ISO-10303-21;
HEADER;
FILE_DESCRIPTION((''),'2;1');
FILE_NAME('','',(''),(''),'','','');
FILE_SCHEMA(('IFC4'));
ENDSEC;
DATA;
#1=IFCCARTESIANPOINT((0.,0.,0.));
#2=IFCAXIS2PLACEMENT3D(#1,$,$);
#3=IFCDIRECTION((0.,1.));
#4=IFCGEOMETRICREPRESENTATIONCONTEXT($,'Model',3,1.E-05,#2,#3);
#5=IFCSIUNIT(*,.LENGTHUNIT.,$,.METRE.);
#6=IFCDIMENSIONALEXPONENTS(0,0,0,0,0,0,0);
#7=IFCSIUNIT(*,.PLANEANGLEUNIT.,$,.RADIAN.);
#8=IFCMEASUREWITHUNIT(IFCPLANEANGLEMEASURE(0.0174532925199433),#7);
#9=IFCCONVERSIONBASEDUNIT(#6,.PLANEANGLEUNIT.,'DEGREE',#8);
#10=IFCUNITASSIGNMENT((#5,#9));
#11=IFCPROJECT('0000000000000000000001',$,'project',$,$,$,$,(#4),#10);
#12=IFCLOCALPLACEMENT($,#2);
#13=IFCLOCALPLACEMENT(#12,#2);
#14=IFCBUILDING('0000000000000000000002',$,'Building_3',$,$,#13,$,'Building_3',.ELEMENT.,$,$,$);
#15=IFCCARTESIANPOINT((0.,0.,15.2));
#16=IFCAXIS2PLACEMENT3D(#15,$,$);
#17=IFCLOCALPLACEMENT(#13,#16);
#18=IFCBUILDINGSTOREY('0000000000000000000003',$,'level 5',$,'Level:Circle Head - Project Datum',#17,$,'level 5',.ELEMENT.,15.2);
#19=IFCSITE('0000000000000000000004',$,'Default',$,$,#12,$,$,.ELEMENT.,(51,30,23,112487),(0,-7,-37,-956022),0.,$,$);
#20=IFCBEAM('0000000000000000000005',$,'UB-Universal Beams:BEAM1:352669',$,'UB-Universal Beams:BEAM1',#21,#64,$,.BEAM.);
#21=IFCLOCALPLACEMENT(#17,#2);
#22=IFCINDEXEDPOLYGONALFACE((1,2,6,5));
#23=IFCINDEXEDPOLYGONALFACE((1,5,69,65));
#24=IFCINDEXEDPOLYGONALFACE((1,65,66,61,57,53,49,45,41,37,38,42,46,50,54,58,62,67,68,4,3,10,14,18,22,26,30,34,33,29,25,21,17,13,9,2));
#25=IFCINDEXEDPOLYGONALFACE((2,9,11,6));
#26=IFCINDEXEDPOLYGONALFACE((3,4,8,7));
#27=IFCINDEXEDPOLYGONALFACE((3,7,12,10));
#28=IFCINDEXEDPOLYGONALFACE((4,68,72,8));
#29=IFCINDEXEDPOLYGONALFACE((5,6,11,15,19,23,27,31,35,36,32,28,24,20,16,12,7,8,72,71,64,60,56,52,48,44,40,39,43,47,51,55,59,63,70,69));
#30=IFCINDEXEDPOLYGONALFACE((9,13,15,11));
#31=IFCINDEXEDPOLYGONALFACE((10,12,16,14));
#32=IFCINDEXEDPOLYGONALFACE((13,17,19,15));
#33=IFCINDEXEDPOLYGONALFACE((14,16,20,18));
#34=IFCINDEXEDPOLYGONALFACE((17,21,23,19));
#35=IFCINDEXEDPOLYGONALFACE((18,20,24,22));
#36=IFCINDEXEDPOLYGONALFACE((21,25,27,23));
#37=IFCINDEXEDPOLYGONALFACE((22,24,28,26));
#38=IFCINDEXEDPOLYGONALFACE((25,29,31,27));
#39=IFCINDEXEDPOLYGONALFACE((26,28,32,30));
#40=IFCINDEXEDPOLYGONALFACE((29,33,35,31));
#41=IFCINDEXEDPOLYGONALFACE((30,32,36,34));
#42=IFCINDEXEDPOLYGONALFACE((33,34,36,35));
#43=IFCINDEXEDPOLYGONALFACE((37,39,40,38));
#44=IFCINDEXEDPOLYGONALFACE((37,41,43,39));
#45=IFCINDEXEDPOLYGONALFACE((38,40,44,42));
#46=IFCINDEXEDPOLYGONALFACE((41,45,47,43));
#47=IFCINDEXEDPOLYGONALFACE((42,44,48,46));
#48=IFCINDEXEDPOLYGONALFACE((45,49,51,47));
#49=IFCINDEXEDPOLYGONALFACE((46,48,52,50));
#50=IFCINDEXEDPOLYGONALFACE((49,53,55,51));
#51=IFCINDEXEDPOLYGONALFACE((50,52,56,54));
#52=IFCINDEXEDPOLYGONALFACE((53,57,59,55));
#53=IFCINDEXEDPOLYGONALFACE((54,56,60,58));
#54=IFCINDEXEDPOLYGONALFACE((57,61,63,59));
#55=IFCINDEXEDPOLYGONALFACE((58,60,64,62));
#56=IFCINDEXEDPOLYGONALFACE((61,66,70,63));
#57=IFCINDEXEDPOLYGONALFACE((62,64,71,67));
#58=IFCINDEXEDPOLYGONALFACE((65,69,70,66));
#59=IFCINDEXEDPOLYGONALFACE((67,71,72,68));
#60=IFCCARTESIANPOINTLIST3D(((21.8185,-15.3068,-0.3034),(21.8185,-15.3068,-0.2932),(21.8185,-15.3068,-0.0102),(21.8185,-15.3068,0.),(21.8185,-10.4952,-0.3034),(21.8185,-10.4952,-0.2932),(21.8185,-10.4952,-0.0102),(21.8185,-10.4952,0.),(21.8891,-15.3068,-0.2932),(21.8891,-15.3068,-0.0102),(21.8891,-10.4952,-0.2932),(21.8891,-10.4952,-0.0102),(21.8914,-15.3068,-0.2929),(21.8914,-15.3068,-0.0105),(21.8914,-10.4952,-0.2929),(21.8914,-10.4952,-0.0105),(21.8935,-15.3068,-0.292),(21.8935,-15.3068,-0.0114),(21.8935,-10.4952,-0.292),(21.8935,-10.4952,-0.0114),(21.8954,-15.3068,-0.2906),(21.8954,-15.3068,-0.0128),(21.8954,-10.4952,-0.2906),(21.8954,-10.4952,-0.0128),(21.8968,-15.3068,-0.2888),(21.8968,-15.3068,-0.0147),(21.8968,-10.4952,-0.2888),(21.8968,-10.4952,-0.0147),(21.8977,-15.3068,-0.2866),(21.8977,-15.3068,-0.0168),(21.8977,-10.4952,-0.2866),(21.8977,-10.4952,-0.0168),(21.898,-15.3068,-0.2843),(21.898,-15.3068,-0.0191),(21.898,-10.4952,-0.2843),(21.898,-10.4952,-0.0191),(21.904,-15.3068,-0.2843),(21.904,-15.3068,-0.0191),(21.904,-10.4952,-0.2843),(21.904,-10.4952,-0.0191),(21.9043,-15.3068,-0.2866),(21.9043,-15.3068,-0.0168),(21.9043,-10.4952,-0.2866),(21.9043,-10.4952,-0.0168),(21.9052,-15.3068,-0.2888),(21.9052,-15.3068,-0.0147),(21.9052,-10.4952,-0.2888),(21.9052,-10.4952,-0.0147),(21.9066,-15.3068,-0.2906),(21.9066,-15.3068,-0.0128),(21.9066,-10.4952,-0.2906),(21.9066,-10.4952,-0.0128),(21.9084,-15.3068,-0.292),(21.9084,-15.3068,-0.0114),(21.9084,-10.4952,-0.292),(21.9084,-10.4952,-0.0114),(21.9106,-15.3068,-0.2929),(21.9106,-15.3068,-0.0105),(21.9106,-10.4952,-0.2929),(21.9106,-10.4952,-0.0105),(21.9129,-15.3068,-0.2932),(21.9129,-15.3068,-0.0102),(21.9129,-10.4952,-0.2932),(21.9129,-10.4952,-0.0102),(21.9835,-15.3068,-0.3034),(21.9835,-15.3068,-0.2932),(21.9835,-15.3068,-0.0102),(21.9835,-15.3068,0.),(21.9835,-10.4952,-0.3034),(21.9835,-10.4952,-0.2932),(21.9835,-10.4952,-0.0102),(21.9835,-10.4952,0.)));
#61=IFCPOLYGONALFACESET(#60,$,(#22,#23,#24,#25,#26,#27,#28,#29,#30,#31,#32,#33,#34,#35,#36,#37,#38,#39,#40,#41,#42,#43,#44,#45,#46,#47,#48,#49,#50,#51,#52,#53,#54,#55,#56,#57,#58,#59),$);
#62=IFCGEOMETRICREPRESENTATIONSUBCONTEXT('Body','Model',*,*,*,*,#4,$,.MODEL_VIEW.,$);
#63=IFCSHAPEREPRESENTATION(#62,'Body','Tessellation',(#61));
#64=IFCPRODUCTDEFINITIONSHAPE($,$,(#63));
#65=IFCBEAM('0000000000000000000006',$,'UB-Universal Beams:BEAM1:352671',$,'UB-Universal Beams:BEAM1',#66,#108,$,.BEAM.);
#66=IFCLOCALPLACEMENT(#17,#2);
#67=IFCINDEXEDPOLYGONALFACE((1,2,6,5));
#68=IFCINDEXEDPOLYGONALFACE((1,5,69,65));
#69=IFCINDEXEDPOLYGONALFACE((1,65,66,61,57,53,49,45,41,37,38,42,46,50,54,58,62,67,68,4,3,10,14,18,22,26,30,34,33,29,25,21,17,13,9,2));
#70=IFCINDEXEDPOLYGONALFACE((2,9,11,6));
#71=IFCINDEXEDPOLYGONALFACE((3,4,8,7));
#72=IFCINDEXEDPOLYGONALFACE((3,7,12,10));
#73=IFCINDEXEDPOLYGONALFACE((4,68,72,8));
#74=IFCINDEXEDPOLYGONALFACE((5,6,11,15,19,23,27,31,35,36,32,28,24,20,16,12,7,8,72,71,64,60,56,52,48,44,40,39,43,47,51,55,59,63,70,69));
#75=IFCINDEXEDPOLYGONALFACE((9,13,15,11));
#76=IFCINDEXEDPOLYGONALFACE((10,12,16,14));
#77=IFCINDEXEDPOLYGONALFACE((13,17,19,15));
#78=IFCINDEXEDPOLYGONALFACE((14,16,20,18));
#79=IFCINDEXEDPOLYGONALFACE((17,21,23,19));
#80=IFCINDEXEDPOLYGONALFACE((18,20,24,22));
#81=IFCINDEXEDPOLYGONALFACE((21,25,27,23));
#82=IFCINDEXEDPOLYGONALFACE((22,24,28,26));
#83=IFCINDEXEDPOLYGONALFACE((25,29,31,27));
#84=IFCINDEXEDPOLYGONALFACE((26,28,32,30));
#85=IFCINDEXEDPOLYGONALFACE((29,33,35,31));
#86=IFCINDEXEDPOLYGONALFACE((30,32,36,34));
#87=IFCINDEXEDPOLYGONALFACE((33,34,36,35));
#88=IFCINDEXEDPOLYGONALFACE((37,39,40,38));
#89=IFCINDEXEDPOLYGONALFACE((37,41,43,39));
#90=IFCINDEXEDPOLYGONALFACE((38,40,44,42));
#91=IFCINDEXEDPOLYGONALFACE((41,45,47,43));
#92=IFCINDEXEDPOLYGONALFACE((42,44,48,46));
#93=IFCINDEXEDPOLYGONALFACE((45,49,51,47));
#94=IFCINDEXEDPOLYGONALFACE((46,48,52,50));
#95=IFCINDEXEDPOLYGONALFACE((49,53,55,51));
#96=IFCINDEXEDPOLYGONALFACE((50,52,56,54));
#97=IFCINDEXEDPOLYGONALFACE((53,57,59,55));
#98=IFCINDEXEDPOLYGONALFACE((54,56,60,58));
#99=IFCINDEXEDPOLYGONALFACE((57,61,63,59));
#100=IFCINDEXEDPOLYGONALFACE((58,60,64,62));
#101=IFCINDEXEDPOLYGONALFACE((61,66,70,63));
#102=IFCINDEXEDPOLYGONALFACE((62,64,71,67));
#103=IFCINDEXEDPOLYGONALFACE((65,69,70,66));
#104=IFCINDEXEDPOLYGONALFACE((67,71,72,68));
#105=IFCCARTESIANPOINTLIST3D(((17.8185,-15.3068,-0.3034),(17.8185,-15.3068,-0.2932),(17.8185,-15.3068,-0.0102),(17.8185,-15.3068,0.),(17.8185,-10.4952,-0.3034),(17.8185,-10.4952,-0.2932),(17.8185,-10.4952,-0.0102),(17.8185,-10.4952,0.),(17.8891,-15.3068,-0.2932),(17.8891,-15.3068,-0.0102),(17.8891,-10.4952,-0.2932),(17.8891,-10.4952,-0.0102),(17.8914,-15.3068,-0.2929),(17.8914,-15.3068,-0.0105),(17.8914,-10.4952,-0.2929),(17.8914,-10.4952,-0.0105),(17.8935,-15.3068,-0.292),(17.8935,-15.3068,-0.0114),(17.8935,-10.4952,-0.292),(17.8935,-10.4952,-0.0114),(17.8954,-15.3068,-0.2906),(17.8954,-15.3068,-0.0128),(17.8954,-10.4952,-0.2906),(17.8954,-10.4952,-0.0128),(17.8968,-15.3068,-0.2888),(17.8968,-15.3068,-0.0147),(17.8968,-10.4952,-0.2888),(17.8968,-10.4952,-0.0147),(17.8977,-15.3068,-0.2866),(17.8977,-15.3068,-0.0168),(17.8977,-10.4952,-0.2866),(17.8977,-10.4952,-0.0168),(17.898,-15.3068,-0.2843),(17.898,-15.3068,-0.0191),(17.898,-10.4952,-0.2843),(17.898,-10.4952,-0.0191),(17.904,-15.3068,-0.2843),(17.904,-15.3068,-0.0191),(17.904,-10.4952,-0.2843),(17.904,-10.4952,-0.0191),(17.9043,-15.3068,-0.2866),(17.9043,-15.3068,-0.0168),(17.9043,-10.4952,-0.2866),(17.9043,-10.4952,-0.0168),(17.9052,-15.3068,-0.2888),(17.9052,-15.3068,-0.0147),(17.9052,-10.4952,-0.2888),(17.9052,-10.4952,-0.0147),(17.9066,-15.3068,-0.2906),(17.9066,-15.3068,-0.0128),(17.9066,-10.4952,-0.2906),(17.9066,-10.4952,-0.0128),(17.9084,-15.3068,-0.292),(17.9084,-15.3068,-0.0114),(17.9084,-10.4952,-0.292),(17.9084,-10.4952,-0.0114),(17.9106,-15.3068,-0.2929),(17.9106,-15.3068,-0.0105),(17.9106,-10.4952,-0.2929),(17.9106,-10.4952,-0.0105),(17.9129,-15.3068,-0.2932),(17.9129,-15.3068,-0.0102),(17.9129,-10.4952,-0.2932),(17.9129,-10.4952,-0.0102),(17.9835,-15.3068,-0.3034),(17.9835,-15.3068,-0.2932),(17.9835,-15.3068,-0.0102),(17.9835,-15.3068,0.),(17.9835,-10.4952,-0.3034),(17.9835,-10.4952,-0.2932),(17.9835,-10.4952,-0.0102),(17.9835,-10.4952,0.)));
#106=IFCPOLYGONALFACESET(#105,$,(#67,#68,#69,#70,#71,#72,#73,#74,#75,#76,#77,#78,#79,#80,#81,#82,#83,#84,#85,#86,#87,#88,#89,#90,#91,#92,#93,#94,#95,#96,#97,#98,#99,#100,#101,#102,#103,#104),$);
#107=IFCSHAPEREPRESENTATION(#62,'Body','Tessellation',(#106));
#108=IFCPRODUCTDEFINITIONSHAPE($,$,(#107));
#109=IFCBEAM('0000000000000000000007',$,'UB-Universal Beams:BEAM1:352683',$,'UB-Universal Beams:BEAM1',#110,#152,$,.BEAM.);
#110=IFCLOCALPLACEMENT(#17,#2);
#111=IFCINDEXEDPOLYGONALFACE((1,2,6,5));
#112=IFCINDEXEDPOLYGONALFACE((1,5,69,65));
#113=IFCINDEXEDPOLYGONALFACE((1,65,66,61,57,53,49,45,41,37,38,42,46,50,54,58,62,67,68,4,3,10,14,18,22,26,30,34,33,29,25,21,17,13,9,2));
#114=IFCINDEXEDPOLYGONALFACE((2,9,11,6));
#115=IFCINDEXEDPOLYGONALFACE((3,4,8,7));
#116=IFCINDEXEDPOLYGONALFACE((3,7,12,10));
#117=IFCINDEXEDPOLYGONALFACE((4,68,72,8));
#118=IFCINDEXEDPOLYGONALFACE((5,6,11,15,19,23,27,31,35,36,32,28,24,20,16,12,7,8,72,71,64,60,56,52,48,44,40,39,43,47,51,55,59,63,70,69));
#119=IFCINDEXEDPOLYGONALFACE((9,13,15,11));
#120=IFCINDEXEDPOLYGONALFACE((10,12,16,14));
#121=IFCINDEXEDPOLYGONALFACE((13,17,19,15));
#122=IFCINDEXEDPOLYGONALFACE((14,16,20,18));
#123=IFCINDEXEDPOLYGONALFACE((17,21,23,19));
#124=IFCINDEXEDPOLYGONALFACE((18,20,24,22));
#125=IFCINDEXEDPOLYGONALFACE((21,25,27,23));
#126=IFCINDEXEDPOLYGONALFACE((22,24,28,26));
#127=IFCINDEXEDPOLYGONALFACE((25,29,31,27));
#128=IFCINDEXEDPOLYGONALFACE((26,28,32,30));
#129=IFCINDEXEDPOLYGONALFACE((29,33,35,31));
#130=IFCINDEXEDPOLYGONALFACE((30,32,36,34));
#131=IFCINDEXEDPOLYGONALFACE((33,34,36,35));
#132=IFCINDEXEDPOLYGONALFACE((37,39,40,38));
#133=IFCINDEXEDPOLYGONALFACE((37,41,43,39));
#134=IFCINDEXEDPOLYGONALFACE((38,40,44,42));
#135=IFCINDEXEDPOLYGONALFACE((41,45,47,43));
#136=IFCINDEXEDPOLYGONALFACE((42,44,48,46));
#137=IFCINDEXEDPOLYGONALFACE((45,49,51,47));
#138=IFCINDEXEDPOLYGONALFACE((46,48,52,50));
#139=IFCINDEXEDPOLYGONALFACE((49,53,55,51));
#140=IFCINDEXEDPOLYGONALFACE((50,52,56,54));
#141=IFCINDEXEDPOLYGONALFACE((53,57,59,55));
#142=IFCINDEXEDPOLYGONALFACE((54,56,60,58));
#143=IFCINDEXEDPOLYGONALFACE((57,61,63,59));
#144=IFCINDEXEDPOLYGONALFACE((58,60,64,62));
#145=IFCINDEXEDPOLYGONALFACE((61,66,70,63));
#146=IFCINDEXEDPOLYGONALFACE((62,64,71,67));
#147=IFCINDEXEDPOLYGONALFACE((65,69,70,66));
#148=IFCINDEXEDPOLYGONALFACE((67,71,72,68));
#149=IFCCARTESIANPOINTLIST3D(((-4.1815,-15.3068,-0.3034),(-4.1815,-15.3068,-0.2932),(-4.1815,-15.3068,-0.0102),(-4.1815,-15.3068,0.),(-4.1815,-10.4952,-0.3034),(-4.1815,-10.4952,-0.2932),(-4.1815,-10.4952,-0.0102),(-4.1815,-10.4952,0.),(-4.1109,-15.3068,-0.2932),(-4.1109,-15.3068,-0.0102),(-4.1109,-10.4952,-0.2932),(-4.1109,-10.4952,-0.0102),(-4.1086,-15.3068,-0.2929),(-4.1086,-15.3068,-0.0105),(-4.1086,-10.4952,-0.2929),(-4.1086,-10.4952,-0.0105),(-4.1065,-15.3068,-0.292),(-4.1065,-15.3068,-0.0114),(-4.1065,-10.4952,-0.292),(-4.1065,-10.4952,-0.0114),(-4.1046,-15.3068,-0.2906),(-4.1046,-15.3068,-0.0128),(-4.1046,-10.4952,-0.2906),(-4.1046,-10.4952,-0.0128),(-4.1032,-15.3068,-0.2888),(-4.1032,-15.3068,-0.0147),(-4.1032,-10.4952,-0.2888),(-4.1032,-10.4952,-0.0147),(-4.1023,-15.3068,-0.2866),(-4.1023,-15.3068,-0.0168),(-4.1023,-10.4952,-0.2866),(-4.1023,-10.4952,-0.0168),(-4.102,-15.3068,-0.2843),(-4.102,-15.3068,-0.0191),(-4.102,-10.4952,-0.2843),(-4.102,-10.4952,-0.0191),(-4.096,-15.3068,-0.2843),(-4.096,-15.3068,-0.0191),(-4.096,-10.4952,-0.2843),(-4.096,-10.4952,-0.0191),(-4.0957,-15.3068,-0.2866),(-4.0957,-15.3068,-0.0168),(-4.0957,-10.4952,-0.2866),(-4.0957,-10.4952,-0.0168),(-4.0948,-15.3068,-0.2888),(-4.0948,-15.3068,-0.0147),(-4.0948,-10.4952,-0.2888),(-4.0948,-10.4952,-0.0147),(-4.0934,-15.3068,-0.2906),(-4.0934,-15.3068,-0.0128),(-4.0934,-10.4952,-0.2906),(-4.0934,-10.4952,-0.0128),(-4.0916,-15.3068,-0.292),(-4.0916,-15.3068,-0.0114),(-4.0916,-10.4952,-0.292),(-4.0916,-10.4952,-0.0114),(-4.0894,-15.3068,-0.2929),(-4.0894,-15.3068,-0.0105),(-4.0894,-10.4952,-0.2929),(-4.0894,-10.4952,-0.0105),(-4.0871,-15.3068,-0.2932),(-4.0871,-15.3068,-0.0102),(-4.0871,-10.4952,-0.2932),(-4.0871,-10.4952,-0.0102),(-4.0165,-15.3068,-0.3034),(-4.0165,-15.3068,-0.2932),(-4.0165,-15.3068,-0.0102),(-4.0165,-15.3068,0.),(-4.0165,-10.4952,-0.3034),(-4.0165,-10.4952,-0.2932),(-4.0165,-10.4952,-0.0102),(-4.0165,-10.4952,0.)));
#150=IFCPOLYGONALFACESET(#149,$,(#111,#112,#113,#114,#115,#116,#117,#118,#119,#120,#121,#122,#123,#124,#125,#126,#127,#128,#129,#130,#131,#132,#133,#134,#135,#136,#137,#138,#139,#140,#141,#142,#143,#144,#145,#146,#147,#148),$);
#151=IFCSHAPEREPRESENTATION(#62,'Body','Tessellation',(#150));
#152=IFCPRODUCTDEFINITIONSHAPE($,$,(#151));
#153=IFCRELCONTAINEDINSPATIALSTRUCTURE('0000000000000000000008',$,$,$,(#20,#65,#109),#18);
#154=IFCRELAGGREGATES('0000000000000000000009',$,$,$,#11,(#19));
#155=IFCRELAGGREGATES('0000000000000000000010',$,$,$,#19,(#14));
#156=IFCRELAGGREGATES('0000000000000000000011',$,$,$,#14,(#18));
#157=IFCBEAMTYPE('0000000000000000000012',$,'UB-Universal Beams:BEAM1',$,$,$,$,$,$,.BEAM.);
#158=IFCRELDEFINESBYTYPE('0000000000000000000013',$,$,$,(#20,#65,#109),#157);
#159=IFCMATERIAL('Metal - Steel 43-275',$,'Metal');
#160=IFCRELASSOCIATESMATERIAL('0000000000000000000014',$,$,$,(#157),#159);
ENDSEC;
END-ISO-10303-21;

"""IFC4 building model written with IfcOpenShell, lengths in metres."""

from ifc_helpers import new_model, entity, si_unit, converted_unit, direction, frame, frame_2d, origin, place, context, subcontext, project, spatial, polyline, circle_curve, parameter, trimmed, segment, composite_curve, outline, extrude, source, transform, mapped, material, material_profile, profile_set, type_object, type_shapes, element, save


model = new_model("IFC4")

# Units and contexts
model_context = context("Model", 3, precision=1e-05, world=origin(), true_north=direction((0.0, 1.0)))
body_context = subcontext(model_context, "Body", "Model", "MODEL_VIEW")
ifc_project = project(units=[si_unit("LENGTHUNIT", "METRE"), converted_unit("PLANEANGLEUNIT", "DEGREE", entity("IfcPlaneAngleMeasure", 0.0174532925199433), si_unit("PLANEANGLEUNIT", "RADIAN"), dimensions=[0, 0, 0, 0, 0, 0, 0])], contexts=[model_context])

# Site, building, storey
site_placement = place(None, origin())
site = spatial("IfcSite", under=ifc_project, at=site_placement, Name="Default", CompositionType="ELEMENT", RefLatitude=(51, 30, 23, 112487), RefLongitude=(0, -7, -37, -956022), RefElevation=0.0)
building_placement = place(site_placement, origin())
building = spatial("IfcBuilding", under=site, at=building_placement, Name="Building_3", LongName="Building_3", CompositionType="ELEMENT")
storey_placement = place(building_placement, frame((0.0, 0.0, 15.2)))
storey = spatial("IfcBuildingStorey", under=building, at=storey_placement, Name="level 5", ObjectType="Level:Circle Head - Project Datum", LongName="level 5", CompositionType="ELEMENT", Elevation=15.2)

# Beams
ifc_material_1 = material(Name="Metal - Steel 43-275", Category="Metal")
ifc_material_profile = material_profile(ifc_material_1, outline(composite_curve([segment(polyline([(-0.0825, -0.1415), (-0.0825, -0.1517)]), True, "CONTINUOUS"), segment(polyline([(-0.0825, -0.1517), (0.0825, -0.1517)]), True, "CONTINUOUS"), segment(polyline([(0.0825, -0.1517), (0.0825, -0.1415)]), True, "CONTINUOUS"), segment(polyline([(0.0825, -0.1415), (0.0119, -0.1415)]), True, "CONTINUOUS"), segment(trimmed(circle_curve(frame_2d((0.0119, -0.1326), x_axis=(1.0, 0.0)), 0.0089), [parameter(180.0)], [parameter(270.0)], True, "PARAMETER"), False, "CONTINUOUS"), segment(polyline([(0.003, -0.1326), (0.003, 0.1326)]), True, "CONTINUOUS"), segment(trimmed(circle_curve(frame_2d((0.0119, 0.1326), x_axis=(1.0, 0.0)), 0.0089), [parameter(90.0)], [parameter(180.0)], True, "PARAMETER"), False, "CONTINUOUS"), segment(polyline([(0.0119, 0.1415), (0.0825, 0.1415)]), True, "CONTINUOUS"), segment(polyline([(0.0825, 0.1415), (0.0825, 0.1517)]), True, "CONTINUOUS"), segment(polyline([(0.0825, 0.1517), (-0.0825, 0.1517)]), True, "CONTINUOUS"), segment(polyline([(-0.0825, 0.1517), (-0.0825, 0.1415)]), True, "CONTINUOUS"), segment(polyline([(-0.0825, 0.1415), (-0.0119, 0.1415)]), True, "CONTINUOUS"), segment(trimmed(circle_curve(frame_2d((-0.0119, 0.1326), x_axis=(1.0, 0.0)), 0.0089), [parameter(360.0)], [parameter(90.0)], True, "PARAMETER"), False, "CONTINUOUS"), segment(polyline([(-0.003, 0.1326), (-0.003, -0.1326)]), True, "CONTINUOUS"), segment(trimmed(circle_curve(frame_2d((-0.0119, -0.1326), x_axis=(1.0, 0.0)), 0.0089), [parameter(270.0)], [parameter(360.0)], True, "PARAMETER"), False, "CONTINUOUS"), segment(polyline([(-0.0119, -0.1415), (-0.0825, -0.1415)]), True, "CONTINUOUS")], self_intersect=False)), Name="BEAM1")
ifc_profile_set = profile_set([ifc_material_profile], Name="BEAM1")
beam_type_1 = type_object("IfcBeamType", Name="UB-Universal Beams:BEAM1", PredefinedType="BEAM", material=ifc_profile_set)
shared_shape_1 = source(origin(), body_context, "Body", "SweptSolid", [
    extrude(outline(composite_curve([segment(polyline([(-0.0825, -0.1415), (-0.0825, -0.1517)]), True, "CONTINUOUS"), segment(polyline([(-0.0825, -0.1517), (0.0825, -0.1517)]), True, "CONTINUOUS"), segment(polyline([(0.0825, -0.1517), (0.0825, -0.1415)]), True, "CONTINUOUS"), segment(polyline([(0.0825, -0.1415), (0.0119, -0.1415)]), True, "CONTINUOUS"), segment(trimmed(circle_curve(frame_2d((0.0119, -0.1326), x_axis=(0.0, -1.0)), 0.0089), [parameter(270.0)], [parameter(360.0)], True, "PARAMETER"), False, "CONTINUOUS"), segment(polyline([(0.003, -0.1326), (0.003, 0.1326)]), True, "CONTINUOUS"), segment(trimmed(circle_curve(frame_2d((0.0119, 0.1326), x_axis=(-1.0, 0.0)), 0.0089), [parameter(270.0)], [parameter(360.0)], True, "PARAMETER"), False, "CONTINUOUS"), segment(polyline([(0.0119, 0.1415), (0.0825, 0.1415)]), True, "CONTINUOUS"), segment(polyline([(0.0825, 0.1415), (0.0825, 0.1517)]), True, "CONTINUOUS"), segment(polyline([(0.0825, 0.1517), (-0.0825, 0.1517)]), True, "CONTINUOUS"), segment(polyline([(-0.0825, 0.1517), (-0.0825, 0.1415)]), True, "CONTINUOUS"), segment(polyline([(-0.0825, 0.1415), (-0.0119, 0.1415)]), True, "CONTINUOUS"), segment(trimmed(circle_curve(frame_2d((-0.0119, 0.1326), x_axis=(0.0, 1.0)), 0.0089), [parameter(270.0)], [parameter(360.0)], True, "PARAMETER"), False, "CONTINUOUS"), segment(polyline([(-0.003, 0.1326), (-0.003, -0.1326)]), True, "CONTINUOUS"), segment(trimmed(circle_curve(frame_2d((-0.0119, -0.1326), x_axis=(1.0, 0.0)), 0.0089), [parameter(270.0)], [parameter(0.0)], True, "PARAMETER"), False, "CONTINUOUS"), segment(polyline([(-0.0119, -0.1415), (-0.0825, -0.1415)]), True, "CONTINUOUS")], self_intersect=False)), frame((-2.4058, 0.0, 0.0), z_axis=(-1.0, 0.0, 0.0), x_axis=(0.0, -1.0, 0.0)), (0.0, 0.0, -1.0), 4.8116),
])
type_shapes(beam_type_1, [shared_shape_1])
for number, where, z_axis, x_axis, name in (
    (1, (21.901, -12.901, -0.1517), (0.0, 0.0, 1.0), (0.0, 1.0, 0.0), "UB-Universal Beams:BEAM1:352669"),
    (2, (17.901, -12.901, -0.1517), (0.0, 0.0, 1.0), (0.0, -1.0, 0.0), "UB-Universal Beams:BEAM1:352671"),
    (3, (-4.099, -12.901, -0.1517), (0.0, 0.0, 1.0), (0.0, 1.0, 0.0), "UB-Universal Beams:BEAM1:352683"),
):
    element("IfcBeam", number, at=place(storey_placement, frame(where, z_axis=z_axis, x_axis=x_axis)), inside=storey, type_object=beam_type_1, Name=name, ObjectType="UB-Universal Beams:BEAM1", PredefinedType="BEAM", context=body_context, shape_type="MappedRepresentation", body=[
        mapped(shared_shape_1, transform((0.0, 0.0, 0.0), scale=1.0)),
    ])

save(model, "model.ifc")
